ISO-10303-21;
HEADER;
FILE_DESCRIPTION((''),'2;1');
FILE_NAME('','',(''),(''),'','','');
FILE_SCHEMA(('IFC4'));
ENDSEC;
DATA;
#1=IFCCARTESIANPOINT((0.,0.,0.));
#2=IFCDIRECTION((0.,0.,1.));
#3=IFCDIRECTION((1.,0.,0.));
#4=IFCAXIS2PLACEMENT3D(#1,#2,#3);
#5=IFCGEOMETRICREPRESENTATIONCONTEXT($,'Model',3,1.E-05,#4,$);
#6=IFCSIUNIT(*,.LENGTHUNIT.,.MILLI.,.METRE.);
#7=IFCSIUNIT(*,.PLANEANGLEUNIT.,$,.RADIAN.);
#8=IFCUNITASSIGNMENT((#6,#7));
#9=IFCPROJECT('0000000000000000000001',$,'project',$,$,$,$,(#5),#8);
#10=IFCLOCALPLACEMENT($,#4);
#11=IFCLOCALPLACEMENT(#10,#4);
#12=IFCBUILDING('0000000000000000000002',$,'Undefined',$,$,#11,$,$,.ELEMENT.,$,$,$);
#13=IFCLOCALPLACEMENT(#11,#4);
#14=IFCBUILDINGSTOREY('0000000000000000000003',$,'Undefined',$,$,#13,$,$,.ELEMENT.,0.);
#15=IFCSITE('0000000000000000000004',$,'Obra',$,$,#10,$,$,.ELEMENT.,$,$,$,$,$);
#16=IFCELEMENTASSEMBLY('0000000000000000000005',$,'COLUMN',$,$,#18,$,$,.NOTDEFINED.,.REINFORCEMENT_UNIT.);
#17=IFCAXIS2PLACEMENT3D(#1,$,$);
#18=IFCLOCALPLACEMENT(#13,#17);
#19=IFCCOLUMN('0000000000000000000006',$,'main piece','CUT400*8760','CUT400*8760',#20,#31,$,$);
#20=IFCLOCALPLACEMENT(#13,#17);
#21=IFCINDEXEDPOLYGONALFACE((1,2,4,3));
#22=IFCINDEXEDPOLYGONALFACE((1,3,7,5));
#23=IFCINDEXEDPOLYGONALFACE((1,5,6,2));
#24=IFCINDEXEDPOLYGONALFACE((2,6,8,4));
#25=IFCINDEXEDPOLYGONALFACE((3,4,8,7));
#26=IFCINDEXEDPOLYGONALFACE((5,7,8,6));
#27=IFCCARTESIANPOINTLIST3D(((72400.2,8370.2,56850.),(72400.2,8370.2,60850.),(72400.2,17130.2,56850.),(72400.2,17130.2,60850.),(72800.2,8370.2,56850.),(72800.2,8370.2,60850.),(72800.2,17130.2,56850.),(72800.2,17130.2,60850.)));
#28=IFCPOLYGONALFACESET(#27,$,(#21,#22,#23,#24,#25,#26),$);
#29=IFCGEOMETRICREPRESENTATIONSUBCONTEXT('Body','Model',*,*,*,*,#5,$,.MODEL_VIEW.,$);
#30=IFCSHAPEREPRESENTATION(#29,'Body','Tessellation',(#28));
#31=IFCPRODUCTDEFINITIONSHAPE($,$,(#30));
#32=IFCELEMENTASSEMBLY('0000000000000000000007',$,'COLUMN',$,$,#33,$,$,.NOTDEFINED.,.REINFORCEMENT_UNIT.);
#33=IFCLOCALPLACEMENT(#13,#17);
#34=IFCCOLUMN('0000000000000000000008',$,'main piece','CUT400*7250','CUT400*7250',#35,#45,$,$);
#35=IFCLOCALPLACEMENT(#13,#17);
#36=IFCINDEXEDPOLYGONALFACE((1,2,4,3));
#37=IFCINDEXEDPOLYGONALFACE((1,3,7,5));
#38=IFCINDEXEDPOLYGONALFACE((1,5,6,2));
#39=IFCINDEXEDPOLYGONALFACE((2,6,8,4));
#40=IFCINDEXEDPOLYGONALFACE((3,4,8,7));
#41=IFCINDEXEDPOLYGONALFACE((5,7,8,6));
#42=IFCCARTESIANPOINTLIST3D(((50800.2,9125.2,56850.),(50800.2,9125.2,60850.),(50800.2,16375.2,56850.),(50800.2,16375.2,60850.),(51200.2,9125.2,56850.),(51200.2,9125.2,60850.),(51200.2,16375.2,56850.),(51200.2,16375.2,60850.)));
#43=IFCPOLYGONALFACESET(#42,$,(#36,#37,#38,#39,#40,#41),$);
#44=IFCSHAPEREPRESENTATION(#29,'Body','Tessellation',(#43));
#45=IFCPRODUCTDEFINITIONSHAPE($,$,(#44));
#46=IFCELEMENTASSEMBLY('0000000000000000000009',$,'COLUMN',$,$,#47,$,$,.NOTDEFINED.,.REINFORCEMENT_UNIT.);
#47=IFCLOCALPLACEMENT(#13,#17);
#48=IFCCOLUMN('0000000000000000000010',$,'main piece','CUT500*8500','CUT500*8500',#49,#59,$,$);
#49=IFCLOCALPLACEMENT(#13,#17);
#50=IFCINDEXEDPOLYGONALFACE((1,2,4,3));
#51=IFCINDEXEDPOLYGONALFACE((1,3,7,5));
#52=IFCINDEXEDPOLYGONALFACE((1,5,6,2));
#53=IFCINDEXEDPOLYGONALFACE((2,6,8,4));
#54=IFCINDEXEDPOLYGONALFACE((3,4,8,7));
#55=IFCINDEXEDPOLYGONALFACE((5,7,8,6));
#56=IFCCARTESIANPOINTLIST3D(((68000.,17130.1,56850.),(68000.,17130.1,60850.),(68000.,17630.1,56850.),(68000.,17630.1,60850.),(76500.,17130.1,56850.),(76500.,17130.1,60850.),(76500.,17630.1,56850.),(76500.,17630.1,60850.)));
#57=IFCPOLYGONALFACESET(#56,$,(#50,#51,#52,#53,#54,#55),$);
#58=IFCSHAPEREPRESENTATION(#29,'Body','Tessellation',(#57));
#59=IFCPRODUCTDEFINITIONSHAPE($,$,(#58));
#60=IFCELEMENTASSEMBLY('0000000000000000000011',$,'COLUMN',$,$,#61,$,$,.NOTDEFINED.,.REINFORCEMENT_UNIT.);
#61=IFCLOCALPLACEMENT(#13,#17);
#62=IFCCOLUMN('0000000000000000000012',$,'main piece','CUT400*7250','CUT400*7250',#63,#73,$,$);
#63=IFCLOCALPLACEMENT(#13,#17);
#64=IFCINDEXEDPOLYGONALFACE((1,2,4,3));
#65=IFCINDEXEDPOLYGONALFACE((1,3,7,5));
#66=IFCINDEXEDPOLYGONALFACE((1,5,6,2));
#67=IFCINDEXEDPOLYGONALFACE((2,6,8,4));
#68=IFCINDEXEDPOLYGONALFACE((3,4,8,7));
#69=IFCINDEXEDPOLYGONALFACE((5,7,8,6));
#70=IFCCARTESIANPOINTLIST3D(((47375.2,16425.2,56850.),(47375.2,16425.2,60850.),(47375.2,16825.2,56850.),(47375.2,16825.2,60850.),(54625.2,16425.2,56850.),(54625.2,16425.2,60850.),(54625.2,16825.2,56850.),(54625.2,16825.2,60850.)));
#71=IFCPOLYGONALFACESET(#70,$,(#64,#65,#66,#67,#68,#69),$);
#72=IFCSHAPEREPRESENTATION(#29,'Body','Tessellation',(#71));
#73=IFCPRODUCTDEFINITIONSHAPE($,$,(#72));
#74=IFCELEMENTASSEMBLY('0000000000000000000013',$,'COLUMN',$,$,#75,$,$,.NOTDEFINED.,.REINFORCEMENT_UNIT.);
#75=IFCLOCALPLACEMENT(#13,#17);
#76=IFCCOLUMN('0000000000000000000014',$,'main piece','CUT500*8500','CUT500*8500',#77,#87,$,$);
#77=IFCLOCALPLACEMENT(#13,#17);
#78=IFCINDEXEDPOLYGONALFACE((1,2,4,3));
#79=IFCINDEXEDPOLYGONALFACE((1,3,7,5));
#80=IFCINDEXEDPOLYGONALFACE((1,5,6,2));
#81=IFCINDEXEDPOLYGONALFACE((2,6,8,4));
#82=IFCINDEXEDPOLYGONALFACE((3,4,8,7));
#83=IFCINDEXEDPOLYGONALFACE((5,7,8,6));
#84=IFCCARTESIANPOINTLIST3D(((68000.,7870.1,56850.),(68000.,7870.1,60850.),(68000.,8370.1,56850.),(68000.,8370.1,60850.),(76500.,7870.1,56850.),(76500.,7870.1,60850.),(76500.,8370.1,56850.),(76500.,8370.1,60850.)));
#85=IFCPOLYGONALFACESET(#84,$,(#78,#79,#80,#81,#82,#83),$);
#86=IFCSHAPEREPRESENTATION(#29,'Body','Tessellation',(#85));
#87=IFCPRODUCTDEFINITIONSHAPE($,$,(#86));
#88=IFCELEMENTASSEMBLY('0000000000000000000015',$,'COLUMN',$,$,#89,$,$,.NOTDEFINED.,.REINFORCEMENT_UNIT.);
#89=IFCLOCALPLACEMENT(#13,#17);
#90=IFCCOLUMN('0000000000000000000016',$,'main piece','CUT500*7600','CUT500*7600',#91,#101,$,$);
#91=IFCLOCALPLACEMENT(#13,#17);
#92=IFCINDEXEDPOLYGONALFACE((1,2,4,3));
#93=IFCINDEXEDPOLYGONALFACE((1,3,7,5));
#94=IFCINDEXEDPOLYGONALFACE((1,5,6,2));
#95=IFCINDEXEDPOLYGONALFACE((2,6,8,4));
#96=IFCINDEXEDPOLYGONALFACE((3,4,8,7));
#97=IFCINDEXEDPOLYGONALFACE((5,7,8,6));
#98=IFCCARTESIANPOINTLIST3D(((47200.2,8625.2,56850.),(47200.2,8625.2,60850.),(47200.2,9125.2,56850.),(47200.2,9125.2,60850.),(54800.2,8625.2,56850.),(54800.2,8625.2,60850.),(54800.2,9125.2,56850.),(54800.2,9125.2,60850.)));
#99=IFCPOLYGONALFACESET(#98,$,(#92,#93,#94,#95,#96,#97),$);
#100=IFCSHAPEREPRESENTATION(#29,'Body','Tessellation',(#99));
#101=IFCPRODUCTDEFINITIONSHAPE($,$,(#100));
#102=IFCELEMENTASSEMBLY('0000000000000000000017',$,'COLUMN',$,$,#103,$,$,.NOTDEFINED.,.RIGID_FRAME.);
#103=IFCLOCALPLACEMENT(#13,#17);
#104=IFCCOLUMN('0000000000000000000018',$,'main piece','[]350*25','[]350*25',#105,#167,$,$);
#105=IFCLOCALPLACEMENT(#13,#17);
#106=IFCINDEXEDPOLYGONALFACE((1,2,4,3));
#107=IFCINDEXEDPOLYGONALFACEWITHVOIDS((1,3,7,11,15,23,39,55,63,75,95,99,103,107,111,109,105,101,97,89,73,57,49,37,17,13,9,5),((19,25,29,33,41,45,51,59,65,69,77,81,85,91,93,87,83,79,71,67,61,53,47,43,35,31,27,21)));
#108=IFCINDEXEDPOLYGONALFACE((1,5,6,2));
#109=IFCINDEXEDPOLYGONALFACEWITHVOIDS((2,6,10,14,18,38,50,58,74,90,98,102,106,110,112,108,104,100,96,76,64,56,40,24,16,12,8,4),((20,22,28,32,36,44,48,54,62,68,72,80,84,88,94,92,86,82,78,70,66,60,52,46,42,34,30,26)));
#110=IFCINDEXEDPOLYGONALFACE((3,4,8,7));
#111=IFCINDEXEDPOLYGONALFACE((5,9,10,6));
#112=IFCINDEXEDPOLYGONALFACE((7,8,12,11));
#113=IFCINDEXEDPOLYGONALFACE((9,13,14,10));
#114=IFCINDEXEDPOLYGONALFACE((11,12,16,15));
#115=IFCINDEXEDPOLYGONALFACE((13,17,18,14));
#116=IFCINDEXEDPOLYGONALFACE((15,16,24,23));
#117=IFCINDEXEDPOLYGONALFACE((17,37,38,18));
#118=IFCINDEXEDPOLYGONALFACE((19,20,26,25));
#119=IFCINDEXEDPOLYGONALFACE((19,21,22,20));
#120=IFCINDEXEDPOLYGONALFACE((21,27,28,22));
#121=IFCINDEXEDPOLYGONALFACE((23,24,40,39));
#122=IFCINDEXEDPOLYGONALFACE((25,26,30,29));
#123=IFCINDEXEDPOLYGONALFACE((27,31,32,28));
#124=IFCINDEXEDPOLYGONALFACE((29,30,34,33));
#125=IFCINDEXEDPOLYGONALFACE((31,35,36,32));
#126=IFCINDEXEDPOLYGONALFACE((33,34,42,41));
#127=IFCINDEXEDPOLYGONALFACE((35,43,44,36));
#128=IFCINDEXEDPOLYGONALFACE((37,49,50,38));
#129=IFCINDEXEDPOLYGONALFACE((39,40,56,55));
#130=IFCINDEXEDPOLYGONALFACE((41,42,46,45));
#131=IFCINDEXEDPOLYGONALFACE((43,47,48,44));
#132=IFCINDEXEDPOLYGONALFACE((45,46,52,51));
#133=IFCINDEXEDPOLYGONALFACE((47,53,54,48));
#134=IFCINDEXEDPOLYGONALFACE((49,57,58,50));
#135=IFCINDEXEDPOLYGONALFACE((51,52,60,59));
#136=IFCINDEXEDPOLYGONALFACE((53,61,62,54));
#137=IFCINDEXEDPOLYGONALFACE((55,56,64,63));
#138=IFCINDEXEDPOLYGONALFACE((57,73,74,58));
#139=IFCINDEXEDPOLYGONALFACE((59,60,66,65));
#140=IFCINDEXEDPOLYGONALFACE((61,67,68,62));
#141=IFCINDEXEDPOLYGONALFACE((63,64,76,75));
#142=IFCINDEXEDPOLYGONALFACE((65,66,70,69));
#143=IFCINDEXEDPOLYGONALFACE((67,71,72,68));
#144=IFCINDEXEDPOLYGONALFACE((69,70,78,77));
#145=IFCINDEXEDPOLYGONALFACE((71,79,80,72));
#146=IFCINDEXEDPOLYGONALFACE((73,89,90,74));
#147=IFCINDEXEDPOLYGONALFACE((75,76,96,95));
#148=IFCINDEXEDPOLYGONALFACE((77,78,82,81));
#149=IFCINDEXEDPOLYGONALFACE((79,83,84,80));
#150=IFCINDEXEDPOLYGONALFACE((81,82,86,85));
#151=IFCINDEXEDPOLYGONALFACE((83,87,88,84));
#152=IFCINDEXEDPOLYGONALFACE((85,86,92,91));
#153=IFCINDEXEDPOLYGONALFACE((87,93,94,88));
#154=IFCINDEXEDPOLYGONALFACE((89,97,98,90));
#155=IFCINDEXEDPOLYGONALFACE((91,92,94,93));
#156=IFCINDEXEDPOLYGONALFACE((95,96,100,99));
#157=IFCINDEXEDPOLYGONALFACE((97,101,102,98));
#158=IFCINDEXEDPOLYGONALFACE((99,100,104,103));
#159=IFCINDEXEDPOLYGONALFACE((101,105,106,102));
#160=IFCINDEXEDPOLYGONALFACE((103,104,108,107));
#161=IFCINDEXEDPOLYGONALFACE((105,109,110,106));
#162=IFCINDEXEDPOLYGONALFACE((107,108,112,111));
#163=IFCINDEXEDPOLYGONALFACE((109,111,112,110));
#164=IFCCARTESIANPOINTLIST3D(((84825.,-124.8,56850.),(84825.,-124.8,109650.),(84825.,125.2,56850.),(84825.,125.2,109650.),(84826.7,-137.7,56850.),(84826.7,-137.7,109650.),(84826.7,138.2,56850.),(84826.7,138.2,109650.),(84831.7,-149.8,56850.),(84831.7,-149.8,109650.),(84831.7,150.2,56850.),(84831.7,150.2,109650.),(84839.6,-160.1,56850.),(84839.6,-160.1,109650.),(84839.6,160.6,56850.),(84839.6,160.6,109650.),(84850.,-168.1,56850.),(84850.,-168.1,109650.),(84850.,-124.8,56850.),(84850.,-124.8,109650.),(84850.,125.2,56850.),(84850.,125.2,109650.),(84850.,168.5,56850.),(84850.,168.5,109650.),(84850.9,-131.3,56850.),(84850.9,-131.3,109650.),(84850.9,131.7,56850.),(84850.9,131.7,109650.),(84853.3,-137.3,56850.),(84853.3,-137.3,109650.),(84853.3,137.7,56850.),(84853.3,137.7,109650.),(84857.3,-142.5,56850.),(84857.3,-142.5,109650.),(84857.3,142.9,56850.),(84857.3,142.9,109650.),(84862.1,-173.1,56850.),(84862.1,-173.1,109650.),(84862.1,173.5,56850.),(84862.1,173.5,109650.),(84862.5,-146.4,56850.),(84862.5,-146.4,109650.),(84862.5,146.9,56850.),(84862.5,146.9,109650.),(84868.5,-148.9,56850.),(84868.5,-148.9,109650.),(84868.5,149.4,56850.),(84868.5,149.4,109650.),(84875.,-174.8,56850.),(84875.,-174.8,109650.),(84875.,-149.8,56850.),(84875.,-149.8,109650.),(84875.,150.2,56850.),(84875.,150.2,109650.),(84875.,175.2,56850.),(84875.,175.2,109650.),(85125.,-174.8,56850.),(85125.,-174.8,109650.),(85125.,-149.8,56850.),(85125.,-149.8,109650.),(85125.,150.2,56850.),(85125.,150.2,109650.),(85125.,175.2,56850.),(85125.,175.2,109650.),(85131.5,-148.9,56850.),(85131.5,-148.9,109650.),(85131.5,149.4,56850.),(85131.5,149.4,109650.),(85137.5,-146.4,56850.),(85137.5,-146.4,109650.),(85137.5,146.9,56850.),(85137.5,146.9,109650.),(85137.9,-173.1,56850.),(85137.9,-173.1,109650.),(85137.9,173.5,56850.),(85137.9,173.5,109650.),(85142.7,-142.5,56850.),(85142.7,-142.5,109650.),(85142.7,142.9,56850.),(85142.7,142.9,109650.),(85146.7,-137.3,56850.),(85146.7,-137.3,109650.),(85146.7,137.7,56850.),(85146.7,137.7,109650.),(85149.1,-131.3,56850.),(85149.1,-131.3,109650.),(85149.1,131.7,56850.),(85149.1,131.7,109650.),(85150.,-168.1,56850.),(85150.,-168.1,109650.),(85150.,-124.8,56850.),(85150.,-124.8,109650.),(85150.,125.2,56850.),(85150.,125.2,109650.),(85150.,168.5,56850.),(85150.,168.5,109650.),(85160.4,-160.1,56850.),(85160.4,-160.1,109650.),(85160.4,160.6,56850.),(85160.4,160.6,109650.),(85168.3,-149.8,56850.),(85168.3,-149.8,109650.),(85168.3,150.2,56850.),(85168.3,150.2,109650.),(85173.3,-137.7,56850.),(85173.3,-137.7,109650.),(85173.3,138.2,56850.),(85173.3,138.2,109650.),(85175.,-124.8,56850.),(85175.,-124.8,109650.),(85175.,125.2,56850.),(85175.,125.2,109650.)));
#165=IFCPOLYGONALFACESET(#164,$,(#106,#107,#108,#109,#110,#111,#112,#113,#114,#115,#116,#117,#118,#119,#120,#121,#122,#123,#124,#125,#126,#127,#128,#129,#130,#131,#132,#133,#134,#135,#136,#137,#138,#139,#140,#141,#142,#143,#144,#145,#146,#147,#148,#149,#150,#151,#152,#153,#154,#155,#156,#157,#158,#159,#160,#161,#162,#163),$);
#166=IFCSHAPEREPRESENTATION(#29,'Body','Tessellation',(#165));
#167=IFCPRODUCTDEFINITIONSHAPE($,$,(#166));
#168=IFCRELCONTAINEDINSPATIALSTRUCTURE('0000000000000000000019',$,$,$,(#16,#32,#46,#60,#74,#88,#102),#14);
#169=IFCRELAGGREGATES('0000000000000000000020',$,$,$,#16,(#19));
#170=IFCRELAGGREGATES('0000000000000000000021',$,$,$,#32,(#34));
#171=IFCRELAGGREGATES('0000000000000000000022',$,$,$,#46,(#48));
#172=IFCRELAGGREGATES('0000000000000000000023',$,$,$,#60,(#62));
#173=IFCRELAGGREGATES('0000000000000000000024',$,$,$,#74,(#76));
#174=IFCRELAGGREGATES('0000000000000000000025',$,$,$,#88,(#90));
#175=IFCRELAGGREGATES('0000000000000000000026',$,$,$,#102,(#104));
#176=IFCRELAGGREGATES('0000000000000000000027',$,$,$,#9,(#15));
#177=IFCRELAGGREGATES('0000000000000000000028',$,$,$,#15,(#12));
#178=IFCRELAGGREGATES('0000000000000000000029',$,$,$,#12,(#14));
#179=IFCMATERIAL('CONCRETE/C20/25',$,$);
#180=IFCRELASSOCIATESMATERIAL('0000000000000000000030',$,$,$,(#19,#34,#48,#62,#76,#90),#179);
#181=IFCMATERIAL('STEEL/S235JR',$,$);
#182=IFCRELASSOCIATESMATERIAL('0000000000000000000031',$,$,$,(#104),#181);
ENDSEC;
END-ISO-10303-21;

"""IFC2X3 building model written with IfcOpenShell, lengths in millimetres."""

from ifc_helpers import new_model, si_unit, frame, origin_with_axes, origin_2d_with_axis, place, context, subcontext, project, spatial, rectangle, hollow_rectangle, extrude, material, element, aggregate, save


model = new_model("IFC2X3")

# Units and contexts
model_context = context("Model", 3, precision=1e-05, world=origin_with_axes())
body_context = subcontext(model_context, "Body", "Model", "MODEL_VIEW")
ifc_project = project(units=[si_unit("LENGTHUNIT", "METRE", prefix="MILLI"), si_unit("PLANEANGLEUNIT", "RADIAN")], contexts=[model_context])

# Site, building, storey
site_placement = place(None, origin_with_axes())
site = spatial("IfcSite", under=ifc_project, at=site_placement, Name="Obra", CompositionType="ELEMENT")
building_placement = place(site_placement, origin_with_axes())
building = spatial("IfcBuilding", under=site, at=building_placement, Name="Undefined", CompositionType="ELEMENT")
storey_placement = place(building_placement, origin_with_axes())
storey = spatial("IfcBuildingStorey", under=building, at=storey_placement, Name="Undefined", CompositionType="ELEMENT", Elevation=0.0)

# Element assemblies, columns
ifc_material_1 = material(Name="CONCRETE/C20/25")
assembly_1_placement = place(storey_placement, origin_with_axes())
assembly_1 = element("IfcElementAssembly", 1, at=assembly_1_placement, inside=storey, Name="COLUMN", AssemblyPlace="NOTDEFINED", PredefinedType="REINFORCEMENT_UNIT")
column_1_placement = place(assembly_1_placement, frame((72600.2, 12750.2, 56850.0), z_axis=(0.0, 0.0, 1.0), x_axis=(0.0, -1.0, 0.0)))
column_1 = element("IfcColumn", 2, at=column_1_placement, material=ifc_material_1, Name="main piece", Description="CUT400*8760", ObjectType="CUT400*8760", context=body_context, shape_type="SweptSolid", body=[
    extrude(rectangle(XDim=400.0, YDim=8760.0, at=origin_2d_with_axis()), frame((0.0, 0.0, 4000.0), z_axis=(0.0, 0.0, -1.0), x_axis=(0.0, 1.0, 0.0)), (0.0, 0.0, 1.0), 4000.0),
])
aggregate(assembly_1, [column_1])
assembly_2_placement = place(storey_placement, origin_with_axes())
assembly_2 = element("IfcElementAssembly", 3, at=assembly_2_placement, inside=storey, Name="COLUMN", AssemblyPlace="NOTDEFINED", PredefinedType="REINFORCEMENT_UNIT")
column_2_placement = place(assembly_2_placement, frame((51000.2, 12750.2, 56850.0), z_axis=(0.0, 0.0, 1.0), x_axis=(0.0, -1.0, 0.0)))
column_2 = element("IfcColumn", 4, at=column_2_placement, material=ifc_material_1, Name="main piece", Description="CUT400*7250", ObjectType="CUT400*7250", context=body_context, shape_type="SweptSolid", body=[
    extrude(rectangle(XDim=400.0, YDim=7250.0, at=origin_2d_with_axis()), frame((0.0, 0.0, 4000.0), z_axis=(0.0, 0.0, -1.0), x_axis=(0.0, 1.0, 0.0)), (0.0, 0.0, 1.0), 4000.0),
])
aggregate(assembly_2, [column_2])
assembly_3_placement = place(storey_placement, origin_with_axes())
assembly_3 = element("IfcElementAssembly", 5, at=assembly_3_placement, inside=storey, Name="COLUMN", AssemblyPlace="NOTDEFINED", PredefinedType="REINFORCEMENT_UNIT")
column_3_placement = place(assembly_3_placement, frame((72250.0, 17380.1, 56850.0), z_axis=(0.0, 0.0, 1.0), x_axis=(-1.0, 0.0, 0.0)))
column_3 = element("IfcColumn", 6, at=column_3_placement, material=ifc_material_1, Name="main piece", Description="CUT500*8500", ObjectType="CUT500*8500", context=body_context, shape_type="SweptSolid", body=[
    extrude(rectangle(XDim=500.0, YDim=8500.0, at=origin_2d_with_axis()), frame((0.0, 0.0, 4000.0), z_axis=(0.0, 0.0, -1.0), x_axis=(0.0, 1.0, 0.0)), (0.0, 0.0, 1.0), 4000.0),
])
aggregate(assembly_3, [column_3])
assembly_4_placement = place(storey_placement, origin_with_axes())
assembly_4 = element("IfcElementAssembly", 7, at=assembly_4_placement, inside=storey, Name="COLUMN", AssemblyPlace="NOTDEFINED", PredefinedType="REINFORCEMENT_UNIT")
column_4_placement = place(assembly_4_placement, frame((51000.2, 16625.2, 56850.0), z_axis=(0.0, 0.0, 1.0), x_axis=(-1.0, 0.0, 0.0)))
column_4 = element("IfcColumn", 8, at=column_4_placement, material=ifc_material_1, Name="main piece", Description="CUT400*7250", ObjectType="CUT400*7250", context=body_context, shape_type="SweptSolid", body=[
    extrude(rectangle(XDim=400.0, YDim=7250.0, at=origin_2d_with_axis()), frame((0.0, 0.0, 4000.0), z_axis=(0.0, 0.0, -1.0), x_axis=(0.0, 1.0, 0.0)), (0.0, 0.0, 1.0), 4000.0),
])
aggregate(assembly_4, [column_4])
assembly_5_placement = place(storey_placement, origin_with_axes())
assembly_5 = element("IfcElementAssembly", 9, at=assembly_5_placement, inside=storey, Name="COLUMN", AssemblyPlace="NOTDEFINED", PredefinedType="REINFORCEMENT_UNIT")
column_5_placement = place(assembly_5_placement, frame((72250.0, 8120.1, 56850.0), z_axis=(0.0, 0.0, 1.0), x_axis=(-1.0, 0.0, 0.0)))
column_5 = element("IfcColumn", 10, at=column_5_placement, material=ifc_material_1, Name="main piece", Description="CUT500*8500", ObjectType="CUT500*8500", context=body_context, shape_type="SweptSolid", body=[
    extrude(rectangle(XDim=500.0, YDim=8500.0, at=origin_2d_with_axis()), frame((0.0, 0.0, 4000.0), z_axis=(0.0, 0.0, -1.0), x_axis=(0.0, 1.0, 0.0)), (0.0, 0.0, 1.0), 4000.0),
])
aggregate(assembly_5, [column_5])
assembly_6_placement = place(storey_placement, origin_with_axes())
assembly_6 = element("IfcElementAssembly", 11, at=assembly_6_placement, inside=storey, Name="COLUMN", AssemblyPlace="NOTDEFINED", PredefinedType="REINFORCEMENT_UNIT")
column_6_placement = place(assembly_6_placement, frame((51000.2, 8875.2, 56850.0), z_axis=(0.0, 0.0, 1.0), x_axis=(-1.0, 0.0, 0.0)))
column_6 = element("IfcColumn", 12, at=column_6_placement, material=ifc_material_1, Name="main piece", Description="CUT500*7600", ObjectType="CUT500*7600", context=body_context, shape_type="SweptSolid", body=[
    extrude(rectangle(XDim=500.0, YDim=7600.0, at=origin_2d_with_axis()), frame((0.0, 0.0, 4000.0), z_axis=(0.0, 0.0, -1.0), x_axis=(0.0, 1.0, 0.0)), (0.0, 0.0, 1.0), 4000.0),
])
aggregate(assembly_6, [column_6])
assembly_7_placement = place(storey_placement, origin_with_axes())
assembly_7 = element("IfcElementAssembly", 13, at=assembly_7_placement, inside=storey, Name="COLUMN", AssemblyPlace="NOTDEFINED", PredefinedType="RIGID_FRAME")
ifc_material_2 = material(Name="STEEL/S235JR")
column_7_placement = place(assembly_7_placement, frame((85000.0, 0.2, 56850.0), z_axis=(0.0, 0.0, 1.0), x_axis=(0.0, 1.0, 0.0)))
column_7 = element("IfcColumn", 14, at=column_7_placement, material=ifc_material_2, Name="main piece", Description="[]350*25", ObjectType="[]350*25", context=body_context, shape_type="SweptSolid", body=[
    extrude(hollow_rectangle(XDim=350.0, YDim=350.0, WallThickness=25.0, InnerFilletRadius=25.0, OuterFilletRadius=50.0, at=origin_2d_with_axis()), frame((0.0, 0.0, 52800.0), z_axis=(0.0, 0.0, -1.0), x_axis=(0.0, 1.0, 0.0)), (0.0, 0.0, 1.0), 52800.0),
])

aggregate(assembly_7, [column_7])

save(model, "model.ifc")
